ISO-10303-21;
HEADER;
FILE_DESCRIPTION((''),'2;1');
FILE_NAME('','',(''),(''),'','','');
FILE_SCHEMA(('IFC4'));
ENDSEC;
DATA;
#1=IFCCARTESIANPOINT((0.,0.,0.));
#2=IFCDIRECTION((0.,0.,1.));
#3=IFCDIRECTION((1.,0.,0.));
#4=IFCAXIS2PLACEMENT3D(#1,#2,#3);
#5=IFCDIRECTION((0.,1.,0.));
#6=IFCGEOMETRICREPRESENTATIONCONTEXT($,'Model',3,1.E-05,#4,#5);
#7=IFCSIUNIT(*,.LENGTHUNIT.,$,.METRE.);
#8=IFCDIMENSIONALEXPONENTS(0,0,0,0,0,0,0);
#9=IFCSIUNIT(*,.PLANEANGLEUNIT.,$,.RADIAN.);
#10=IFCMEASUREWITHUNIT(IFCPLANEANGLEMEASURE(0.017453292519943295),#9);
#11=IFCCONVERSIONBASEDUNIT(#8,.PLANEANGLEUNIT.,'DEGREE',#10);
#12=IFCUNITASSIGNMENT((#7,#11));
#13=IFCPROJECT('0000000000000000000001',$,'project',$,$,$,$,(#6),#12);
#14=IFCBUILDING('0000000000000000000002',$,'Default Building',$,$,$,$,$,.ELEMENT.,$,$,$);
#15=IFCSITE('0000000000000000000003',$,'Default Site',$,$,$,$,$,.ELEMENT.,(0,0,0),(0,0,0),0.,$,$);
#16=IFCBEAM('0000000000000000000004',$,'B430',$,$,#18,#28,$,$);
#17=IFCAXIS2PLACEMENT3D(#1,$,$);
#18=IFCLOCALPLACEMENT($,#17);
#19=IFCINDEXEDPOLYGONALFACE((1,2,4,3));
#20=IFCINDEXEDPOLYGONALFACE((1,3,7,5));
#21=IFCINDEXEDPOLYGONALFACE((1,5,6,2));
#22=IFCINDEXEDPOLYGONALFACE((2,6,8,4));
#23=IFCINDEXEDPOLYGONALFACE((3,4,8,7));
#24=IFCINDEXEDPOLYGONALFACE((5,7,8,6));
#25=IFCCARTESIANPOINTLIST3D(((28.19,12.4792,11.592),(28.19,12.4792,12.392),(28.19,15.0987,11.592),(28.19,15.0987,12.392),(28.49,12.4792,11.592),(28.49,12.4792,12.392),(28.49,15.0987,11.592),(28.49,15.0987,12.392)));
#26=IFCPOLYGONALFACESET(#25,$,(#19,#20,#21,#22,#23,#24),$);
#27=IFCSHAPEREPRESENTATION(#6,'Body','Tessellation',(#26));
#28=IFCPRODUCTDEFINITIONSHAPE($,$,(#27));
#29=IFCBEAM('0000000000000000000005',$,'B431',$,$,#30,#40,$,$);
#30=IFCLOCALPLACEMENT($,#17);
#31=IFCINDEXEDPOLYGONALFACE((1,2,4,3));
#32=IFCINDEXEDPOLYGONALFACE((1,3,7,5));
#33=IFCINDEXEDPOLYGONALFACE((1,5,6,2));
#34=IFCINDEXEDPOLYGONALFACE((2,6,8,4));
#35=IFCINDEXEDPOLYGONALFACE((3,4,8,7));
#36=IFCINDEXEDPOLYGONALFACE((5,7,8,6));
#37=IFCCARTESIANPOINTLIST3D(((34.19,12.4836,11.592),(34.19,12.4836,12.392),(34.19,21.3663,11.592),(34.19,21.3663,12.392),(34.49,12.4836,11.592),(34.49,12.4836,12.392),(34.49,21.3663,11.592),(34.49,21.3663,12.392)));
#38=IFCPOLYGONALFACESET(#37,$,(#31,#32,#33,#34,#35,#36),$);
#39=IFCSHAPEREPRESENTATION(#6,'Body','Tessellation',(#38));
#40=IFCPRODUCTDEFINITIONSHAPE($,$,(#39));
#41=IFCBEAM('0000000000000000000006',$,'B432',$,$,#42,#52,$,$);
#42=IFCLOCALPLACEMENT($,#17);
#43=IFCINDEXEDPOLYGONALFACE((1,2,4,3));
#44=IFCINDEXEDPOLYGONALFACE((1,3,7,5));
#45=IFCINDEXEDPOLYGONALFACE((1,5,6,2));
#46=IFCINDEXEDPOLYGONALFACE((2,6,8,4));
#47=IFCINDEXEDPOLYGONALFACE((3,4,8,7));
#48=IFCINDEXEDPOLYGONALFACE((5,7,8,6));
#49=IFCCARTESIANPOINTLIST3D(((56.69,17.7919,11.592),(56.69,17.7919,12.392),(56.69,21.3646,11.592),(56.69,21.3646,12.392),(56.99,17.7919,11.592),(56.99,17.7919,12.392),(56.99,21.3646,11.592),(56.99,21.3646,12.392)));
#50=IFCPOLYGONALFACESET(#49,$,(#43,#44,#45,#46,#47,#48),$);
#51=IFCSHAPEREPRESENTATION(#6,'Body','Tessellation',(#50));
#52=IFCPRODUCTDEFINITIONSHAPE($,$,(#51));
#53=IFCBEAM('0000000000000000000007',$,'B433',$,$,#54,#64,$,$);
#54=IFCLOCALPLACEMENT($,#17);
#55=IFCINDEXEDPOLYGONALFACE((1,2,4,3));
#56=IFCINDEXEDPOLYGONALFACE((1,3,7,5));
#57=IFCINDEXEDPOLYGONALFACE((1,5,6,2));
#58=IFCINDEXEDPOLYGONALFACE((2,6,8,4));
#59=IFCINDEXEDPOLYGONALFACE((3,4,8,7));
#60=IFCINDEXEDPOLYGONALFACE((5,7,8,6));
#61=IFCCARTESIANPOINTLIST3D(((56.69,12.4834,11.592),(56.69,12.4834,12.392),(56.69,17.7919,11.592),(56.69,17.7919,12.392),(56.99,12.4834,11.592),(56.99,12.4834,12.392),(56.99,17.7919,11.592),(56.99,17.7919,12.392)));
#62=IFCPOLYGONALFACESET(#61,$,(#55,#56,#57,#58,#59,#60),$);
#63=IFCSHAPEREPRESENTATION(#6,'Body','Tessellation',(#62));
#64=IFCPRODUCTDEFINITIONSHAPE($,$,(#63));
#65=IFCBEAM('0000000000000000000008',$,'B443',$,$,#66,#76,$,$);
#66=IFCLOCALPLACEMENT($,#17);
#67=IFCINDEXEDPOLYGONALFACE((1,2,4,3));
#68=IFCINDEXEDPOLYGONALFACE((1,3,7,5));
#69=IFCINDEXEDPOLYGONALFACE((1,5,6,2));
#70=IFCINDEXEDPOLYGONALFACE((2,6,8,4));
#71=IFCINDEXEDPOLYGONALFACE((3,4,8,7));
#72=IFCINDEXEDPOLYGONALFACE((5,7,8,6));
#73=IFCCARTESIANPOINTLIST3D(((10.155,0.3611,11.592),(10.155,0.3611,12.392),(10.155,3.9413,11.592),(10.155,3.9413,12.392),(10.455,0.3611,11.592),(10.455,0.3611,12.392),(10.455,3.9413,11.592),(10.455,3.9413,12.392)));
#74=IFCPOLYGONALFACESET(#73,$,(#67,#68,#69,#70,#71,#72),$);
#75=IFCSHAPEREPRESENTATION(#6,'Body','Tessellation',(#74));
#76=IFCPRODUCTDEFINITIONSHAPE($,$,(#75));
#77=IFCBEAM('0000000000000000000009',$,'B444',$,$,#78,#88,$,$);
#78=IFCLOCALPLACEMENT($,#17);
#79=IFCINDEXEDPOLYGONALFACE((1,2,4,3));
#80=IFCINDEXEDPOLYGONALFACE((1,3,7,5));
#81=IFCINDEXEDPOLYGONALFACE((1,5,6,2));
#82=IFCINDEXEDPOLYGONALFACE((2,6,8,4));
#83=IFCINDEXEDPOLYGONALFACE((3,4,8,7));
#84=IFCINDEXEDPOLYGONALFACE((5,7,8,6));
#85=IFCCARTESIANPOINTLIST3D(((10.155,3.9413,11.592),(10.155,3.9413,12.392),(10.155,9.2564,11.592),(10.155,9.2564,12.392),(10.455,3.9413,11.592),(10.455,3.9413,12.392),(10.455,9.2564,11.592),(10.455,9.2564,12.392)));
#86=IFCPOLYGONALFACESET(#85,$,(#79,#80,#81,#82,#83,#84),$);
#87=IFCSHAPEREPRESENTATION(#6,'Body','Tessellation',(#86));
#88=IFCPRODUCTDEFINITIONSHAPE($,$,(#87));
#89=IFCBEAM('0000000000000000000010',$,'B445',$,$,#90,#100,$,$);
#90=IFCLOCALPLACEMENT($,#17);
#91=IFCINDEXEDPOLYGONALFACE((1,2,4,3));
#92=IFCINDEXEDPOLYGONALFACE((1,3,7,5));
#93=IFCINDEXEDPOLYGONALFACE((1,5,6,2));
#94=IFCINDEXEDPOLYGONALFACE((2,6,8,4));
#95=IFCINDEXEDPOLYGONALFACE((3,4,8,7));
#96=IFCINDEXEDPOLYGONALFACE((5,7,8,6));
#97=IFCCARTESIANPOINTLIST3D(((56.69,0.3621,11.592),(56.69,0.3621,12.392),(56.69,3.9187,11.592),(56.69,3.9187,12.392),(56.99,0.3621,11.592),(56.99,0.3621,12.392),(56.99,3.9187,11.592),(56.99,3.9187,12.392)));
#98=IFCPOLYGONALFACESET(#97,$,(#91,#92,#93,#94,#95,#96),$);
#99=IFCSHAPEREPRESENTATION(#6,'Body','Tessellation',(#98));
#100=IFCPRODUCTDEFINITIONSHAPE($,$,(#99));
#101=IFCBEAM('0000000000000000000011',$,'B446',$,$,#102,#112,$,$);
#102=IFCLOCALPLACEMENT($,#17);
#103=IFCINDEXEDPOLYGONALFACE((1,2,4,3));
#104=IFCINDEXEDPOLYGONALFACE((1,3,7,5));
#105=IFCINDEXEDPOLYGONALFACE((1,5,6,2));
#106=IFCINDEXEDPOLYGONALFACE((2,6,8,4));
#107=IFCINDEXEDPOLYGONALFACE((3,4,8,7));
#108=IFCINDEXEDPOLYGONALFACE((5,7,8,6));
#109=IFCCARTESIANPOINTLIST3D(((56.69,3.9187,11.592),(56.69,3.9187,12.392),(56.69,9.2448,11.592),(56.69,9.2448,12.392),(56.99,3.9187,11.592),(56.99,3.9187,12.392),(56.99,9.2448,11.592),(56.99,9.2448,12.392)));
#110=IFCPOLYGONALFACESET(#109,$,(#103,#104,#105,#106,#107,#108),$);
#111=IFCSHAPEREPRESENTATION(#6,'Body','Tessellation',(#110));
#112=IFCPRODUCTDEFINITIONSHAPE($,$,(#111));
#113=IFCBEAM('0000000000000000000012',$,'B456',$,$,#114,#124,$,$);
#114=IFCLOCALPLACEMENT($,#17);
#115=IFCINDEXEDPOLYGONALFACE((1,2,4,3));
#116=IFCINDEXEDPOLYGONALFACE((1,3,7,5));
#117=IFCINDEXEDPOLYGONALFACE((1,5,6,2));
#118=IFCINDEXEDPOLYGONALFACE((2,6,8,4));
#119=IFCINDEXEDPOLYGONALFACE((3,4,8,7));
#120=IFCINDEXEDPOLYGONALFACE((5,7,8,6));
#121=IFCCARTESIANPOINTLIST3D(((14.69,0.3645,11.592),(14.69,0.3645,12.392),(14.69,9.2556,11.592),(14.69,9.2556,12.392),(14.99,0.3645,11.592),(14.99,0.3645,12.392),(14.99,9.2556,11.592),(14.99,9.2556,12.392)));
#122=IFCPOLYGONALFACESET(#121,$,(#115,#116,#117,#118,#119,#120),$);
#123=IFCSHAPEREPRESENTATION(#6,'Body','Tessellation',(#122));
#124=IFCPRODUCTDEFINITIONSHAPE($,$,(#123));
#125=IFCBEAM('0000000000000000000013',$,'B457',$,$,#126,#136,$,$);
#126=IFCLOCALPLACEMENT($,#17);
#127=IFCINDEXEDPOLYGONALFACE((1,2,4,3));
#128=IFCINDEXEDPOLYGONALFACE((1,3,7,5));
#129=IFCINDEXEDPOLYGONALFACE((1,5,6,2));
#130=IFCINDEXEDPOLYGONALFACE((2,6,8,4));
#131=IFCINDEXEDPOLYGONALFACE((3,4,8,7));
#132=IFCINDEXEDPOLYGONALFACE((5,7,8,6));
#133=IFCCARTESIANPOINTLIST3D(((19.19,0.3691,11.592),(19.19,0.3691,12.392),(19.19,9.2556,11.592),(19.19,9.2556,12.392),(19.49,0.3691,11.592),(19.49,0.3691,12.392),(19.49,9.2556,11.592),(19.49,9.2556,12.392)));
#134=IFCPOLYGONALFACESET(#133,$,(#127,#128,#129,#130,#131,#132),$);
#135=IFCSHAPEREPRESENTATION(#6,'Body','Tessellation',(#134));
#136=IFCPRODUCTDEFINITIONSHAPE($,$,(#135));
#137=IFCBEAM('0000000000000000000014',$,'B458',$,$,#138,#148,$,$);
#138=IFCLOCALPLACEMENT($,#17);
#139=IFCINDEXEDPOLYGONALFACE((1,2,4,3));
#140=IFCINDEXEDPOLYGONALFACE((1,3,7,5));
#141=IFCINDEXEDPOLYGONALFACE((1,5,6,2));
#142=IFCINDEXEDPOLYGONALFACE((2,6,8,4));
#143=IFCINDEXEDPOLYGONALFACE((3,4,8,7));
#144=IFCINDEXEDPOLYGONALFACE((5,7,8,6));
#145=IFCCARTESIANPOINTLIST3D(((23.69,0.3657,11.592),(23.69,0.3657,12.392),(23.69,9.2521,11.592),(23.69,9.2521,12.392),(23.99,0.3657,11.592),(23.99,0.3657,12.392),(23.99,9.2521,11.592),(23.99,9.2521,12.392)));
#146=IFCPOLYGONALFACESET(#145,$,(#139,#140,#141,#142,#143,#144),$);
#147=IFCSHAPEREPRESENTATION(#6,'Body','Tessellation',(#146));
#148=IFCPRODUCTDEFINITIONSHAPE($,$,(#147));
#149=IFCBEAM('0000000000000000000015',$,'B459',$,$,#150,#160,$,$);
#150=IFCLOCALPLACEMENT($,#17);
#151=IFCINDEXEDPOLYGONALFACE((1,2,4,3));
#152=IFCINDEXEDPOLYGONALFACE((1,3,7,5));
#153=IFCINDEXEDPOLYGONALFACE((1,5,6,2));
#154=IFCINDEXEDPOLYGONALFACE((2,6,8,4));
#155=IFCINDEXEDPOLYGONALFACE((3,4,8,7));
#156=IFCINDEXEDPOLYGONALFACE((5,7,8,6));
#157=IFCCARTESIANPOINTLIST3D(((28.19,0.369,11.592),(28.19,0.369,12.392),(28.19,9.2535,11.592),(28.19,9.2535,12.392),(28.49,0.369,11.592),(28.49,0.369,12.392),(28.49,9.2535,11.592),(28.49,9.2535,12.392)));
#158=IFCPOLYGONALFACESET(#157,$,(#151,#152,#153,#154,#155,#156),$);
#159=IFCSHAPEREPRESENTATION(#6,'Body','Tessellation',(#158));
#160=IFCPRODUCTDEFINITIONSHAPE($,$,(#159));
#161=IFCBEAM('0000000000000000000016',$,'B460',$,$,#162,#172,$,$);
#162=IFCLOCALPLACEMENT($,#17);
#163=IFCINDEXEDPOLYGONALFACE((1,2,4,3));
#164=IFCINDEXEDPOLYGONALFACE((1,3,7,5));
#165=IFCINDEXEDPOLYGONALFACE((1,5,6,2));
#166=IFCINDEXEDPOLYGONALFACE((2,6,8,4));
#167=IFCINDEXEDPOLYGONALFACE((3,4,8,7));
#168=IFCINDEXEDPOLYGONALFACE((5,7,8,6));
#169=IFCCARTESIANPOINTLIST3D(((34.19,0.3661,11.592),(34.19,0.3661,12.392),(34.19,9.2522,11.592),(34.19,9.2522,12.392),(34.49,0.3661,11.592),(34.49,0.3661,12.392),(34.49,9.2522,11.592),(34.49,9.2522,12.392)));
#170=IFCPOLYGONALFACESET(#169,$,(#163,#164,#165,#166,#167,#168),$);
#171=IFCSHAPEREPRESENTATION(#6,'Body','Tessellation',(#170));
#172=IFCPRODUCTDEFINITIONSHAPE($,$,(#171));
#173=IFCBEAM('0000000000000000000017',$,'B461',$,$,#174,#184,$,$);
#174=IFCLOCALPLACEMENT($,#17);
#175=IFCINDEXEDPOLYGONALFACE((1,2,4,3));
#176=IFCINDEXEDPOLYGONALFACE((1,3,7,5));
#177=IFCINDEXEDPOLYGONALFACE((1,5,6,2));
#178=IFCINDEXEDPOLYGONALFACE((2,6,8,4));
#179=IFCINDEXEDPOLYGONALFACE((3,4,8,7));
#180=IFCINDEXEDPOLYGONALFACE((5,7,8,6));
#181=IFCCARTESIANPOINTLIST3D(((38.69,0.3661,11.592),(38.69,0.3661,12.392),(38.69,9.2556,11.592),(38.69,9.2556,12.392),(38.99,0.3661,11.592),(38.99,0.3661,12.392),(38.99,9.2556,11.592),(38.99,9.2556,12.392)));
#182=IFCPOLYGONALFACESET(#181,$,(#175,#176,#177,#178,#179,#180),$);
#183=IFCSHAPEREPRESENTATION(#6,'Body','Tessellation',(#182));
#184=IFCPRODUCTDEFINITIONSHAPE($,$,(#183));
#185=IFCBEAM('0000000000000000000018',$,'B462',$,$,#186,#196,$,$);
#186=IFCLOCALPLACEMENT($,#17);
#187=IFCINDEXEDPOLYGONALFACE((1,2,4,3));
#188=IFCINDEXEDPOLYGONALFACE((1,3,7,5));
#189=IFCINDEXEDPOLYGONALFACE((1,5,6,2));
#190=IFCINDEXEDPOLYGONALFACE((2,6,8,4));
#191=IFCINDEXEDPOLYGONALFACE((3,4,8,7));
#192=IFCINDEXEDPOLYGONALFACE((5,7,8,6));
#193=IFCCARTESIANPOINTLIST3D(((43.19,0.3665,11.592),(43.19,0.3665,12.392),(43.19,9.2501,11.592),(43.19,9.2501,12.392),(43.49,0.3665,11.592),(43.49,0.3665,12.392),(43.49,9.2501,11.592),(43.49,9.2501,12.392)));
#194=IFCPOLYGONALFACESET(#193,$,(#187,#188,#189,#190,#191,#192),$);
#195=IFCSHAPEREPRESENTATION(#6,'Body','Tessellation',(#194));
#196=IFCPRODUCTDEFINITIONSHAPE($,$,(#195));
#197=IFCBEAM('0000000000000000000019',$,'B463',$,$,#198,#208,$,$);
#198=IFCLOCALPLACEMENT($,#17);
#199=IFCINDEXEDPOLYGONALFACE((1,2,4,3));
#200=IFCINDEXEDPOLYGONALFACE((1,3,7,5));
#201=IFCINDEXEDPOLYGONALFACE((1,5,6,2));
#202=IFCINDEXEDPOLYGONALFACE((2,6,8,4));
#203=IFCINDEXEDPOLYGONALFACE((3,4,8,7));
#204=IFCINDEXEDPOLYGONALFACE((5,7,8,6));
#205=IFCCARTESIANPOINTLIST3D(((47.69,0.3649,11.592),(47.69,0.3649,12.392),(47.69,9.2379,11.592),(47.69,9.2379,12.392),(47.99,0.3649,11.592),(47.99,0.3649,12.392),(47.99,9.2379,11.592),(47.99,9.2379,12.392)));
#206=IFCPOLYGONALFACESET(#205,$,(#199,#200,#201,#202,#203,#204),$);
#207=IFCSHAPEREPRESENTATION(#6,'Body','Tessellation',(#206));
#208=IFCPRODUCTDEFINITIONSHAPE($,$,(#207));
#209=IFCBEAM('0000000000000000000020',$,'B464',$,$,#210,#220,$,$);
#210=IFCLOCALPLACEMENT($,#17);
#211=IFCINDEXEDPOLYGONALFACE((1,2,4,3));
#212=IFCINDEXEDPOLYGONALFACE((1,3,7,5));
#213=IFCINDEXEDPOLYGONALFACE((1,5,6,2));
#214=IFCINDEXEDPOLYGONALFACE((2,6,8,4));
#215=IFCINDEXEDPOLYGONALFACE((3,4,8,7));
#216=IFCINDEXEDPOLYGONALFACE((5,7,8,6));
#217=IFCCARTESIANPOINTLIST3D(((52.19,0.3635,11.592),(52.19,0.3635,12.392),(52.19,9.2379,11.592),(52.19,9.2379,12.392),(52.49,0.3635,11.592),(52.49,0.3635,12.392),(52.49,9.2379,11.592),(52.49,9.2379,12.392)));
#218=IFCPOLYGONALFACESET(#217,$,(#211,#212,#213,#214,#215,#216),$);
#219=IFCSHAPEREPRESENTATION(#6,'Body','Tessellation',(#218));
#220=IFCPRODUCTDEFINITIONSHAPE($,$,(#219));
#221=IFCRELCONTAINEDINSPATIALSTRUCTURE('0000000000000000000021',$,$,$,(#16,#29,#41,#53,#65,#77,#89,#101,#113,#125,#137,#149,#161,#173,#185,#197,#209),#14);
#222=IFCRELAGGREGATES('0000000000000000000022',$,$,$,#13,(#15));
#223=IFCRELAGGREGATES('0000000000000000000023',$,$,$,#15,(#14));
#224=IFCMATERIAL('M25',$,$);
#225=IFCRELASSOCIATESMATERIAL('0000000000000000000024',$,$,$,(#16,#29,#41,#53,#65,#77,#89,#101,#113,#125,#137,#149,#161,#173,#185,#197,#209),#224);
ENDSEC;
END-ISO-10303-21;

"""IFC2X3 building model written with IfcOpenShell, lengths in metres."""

from ifc_helpers import new_model, entity, si_unit, converted_unit, direction, frame, frame_2d, origin_with_axes, place, context, project, spatial, rectangle, extrude, material, element, save


model = new_model("IFC2X3")

# Units and contexts
model_context = context("Model", 3, precision=1e-05, world=origin_with_axes(), true_north=direction((0.0, 1.0, 0.0)))
ifc_project = project(units=[si_unit("LENGTHUNIT", "METRE"), converted_unit("PLANEANGLEUNIT", "DEGREE", entity("IfcPlaneAngleMeasure", 0.017453292519943295), si_unit("PLANEANGLEUNIT", "RADIAN"), dimensions=[0, 0, 0, 0, 0, 0, 0])], contexts=[model_context])

# Site, building
site = spatial("IfcSite", under=ifc_project, Name="Default Site", CompositionType="ELEMENT", RefLatitude=(0, 0, 0), RefLongitude=(0, 0, 0), RefElevation=0.0)
building = spatial("IfcBuilding", under=site, Name="Default Building", CompositionType="ELEMENT")

# Beams
ifc_material = material(Name="M25")
placement = place(None, origin_with_axes())
element("IfcBeam", 1, at=placement, inside=building, material=ifc_material, Name="B430", context=model_context, shape_type="SweptSolid", body=[
    extrude(rectangle(XDim=0.3, YDim=0.8, at=frame_2d((0.0, 0.0), x_axis=(0.0, 1.0, 0.0))), frame((28.34, 15.0987, 11.992), z_axis=(0.0, -1.0, 0.0), x_axis=(0.0, 0.0, -1.0)), (0.0, 0.0, 1.0), 2.6195),
])
element("IfcBeam", 2, at=placement, inside=building, material=ifc_material, Name="B431", context=model_context, shape_type="SweptSolid", body=[
    extrude(rectangle(XDim=0.3, YDim=0.8, at=frame_2d((0.0, 0.0), x_axis=(0.0, 1.0, 0.0))), frame((34.34, 12.4836, 11.992), z_axis=(0.0, 1.0, 0.0), x_axis=(0.0, 0.0, -1.0)), (0.0, 0.0, 1.0), 8.8827),
])
element("IfcBeam", 3, at=placement, inside=building, material=ifc_material, Name="B432", context=model_context, shape_type="SweptSolid", body=[
    extrude(rectangle(XDim=0.3, YDim=0.8, at=frame_2d((0.0, 0.0), x_axis=(0.0, 1.0, 0.0))), frame((56.84, 17.7919, 11.992), z_axis=(0.0, 1.0, 0.0), x_axis=(0.0, 0.0, -1.0)), (0.0, 0.0, 1.0), 3.5727),
])
element("IfcBeam", 4, at=placement, inside=building, material=ifc_material, Name="B433", context=model_context, shape_type="SweptSolid", body=[
    extrude(rectangle(XDim=0.3, YDim=0.8, at=frame_2d((0.0, 0.0), x_axis=(0.0, 1.0, 0.0))), frame((56.84, 12.4834, 11.992), z_axis=(0.0, 1.0, 0.0), x_axis=(0.0, 0.0, -1.0)), (0.0, 0.0, 1.0), 5.3085),
])
element("IfcBeam", 5, at=placement, inside=building, material=ifc_material, Name="B443", context=model_context, shape_type="SweptSolid", body=[
    extrude(rectangle(XDim=0.3, YDim=0.8, at=frame_2d((0.0, 0.0), x_axis=(0.0, 1.0, 0.0))), frame((10.305, 3.9413, 11.992), z_axis=(0.0, -1.0, 0.0), x_axis=(0.0, 0.0, -1.0)), (0.0, 0.0, 1.0), 3.5802),
])
element("IfcBeam", 6, at=placement, inside=building, material=ifc_material, Name="B444", context=model_context, shape_type="SweptSolid", body=[
    extrude(rectangle(XDim=0.3, YDim=0.8, at=frame_2d((0.0, 0.0), x_axis=(0.0, 1.0, 0.0))), frame((10.305, 3.9413, 11.992), z_axis=(0.0, 1.0, 0.0), x_axis=(0.0, 0.0, -1.0)), (0.0, 0.0, 1.0), 5.3151),
])
element("IfcBeam", 7, at=placement, inside=building, material=ifc_material, Name="B445", context=model_context, shape_type="SweptSolid", body=[
    extrude(rectangle(XDim=0.3, YDim=0.8, at=frame_2d((0.0, 0.0), x_axis=(0.0, 1.0, 0.0))), frame((56.84, 0.3621, 11.992), z_axis=(0.0, 1.0, 0.0), x_axis=(0.0, 0.0, -1.0)), (0.0, 0.0, 1.0), 3.5566),
])
element("IfcBeam", 8, at=placement, inside=building, material=ifc_material, Name="B446", context=model_context, shape_type="SweptSolid", body=[
    extrude(rectangle(XDim=0.3, YDim=0.8, at=frame_2d((0.0, 0.0), x_axis=(0.0, 1.0, 0.0))), frame((56.84, 3.9187, 11.992), z_axis=(0.0, 1.0, 0.0), x_axis=(0.0, 0.0, -1.0)), (0.0, 0.0, 1.0), 5.3261),
])
element("IfcBeam", 9, at=placement, inside=building, material=ifc_material, Name="B456", context=model_context, shape_type="SweptSolid", body=[
    extrude(rectangle(XDim=0.3, YDim=0.8, at=frame_2d((0.0, 0.0), x_axis=(0.0, 1.0, 0.0))), frame((14.84, 0.3645, 11.992), z_axis=(0.0, 1.0, 0.0), x_axis=(0.0, 0.0, -1.0)), (0.0, 0.0, 1.0), 8.891),
])
element("IfcBeam", 10, at=placement, inside=building, material=ifc_material, Name="B457", context=model_context, shape_type="SweptSolid", body=[
    extrude(rectangle(XDim=0.3, YDim=0.8, at=frame_2d((0.0, 0.0), x_axis=(0.0, 1.0, 0.0))), frame((19.34, 0.3691, 11.992), z_axis=(0.0, 1.0, 0.0), x_axis=(0.0, 0.0, -1.0)), (0.0, 0.0, 1.0), 8.8865),
])
element("IfcBeam", 11, at=placement, inside=building, material=ifc_material, Name="B458", context=model_context, shape_type="SweptSolid", body=[
    extrude(rectangle(XDim=0.3, YDim=0.8, at=frame_2d((0.0, 0.0), x_axis=(0.0, 1.0, 0.0))), frame((23.84, 0.3657, 11.992), z_axis=(0.0, 1.0, 0.0), x_axis=(0.0, 0.0, -1.0)), (0.0, 0.0, 1.0), 8.8864),
])
element("IfcBeam", 12, at=placement, inside=building, material=ifc_material, Name="B459", context=model_context, shape_type="SweptSolid", body=[
    extrude(rectangle(XDim=0.3, YDim=0.8, at=frame_2d((0.0, 0.0), x_axis=(0.0, 1.0, 0.0))), frame((28.34, 0.369, 11.992), z_axis=(0.0, 1.0, 0.0), x_axis=(0.0, 0.0, -1.0)), (0.0, 0.0, 1.0), 8.8845),
])
element("IfcBeam", 13, at=placement, inside=building, material=ifc_material, Name="B460", context=model_context, shape_type="SweptSolid", body=[
    extrude(rectangle(XDim=0.3, YDim=0.8, at=frame_2d((0.0, 0.0), x_axis=(0.0, 1.0, 0.0))), frame((34.34, 0.3661, 11.992), z_axis=(0.0, 1.0, 0.0), x_axis=(0.0, 0.0, -1.0)), (0.0, 0.0, 1.0), 8.8861),
])
element("IfcBeam", 14, at=placement, inside=building, material=ifc_material, Name="B461", context=model_context, shape_type="SweptSolid", body=[
    extrude(rectangle(XDim=0.3, YDim=0.8, at=frame_2d((0.0, 0.0), x_axis=(0.0, 1.0, 0.0))), frame((38.84, 0.3661, 11.992), z_axis=(0.0, 1.0, 0.0), x_axis=(0.0, 0.0, -1.0)), (0.0, 0.0, 1.0), 8.8895),
])
element("IfcBeam", 15, at=placement, inside=building, material=ifc_material, Name="B462", context=model_context, shape_type="SweptSolid", body=[
    extrude(rectangle(XDim=0.3, YDim=0.8, at=frame_2d((0.0, 0.0), x_axis=(0.0, 1.0, 0.0))), frame((43.34, 0.3665, 11.992), z_axis=(0.0, 1.0, 0.0), x_axis=(0.0, 0.0, -1.0)), (0.0, 0.0, 1.0), 8.8836),
])
element("IfcBeam", 16, at=placement, inside=building, material=ifc_material, Name="B463", context=model_context, shape_type="SweptSolid", body=[
    extrude(rectangle(XDim=0.3, YDim=0.8, at=frame_2d((0.0, 0.0), x_axis=(0.0, 1.0, 0.0))), frame((47.84, 0.3649, 11.992), z_axis=(0.0, 1.0, 0.0), x_axis=(0.0, 0.0, -1.0)), (0.0, 0.0, 1.0), 8.873),
])
element("IfcBeam", 17, at=placement, inside=building, material=ifc_material, Name="B464", context=model_context, shape_type="SweptSolid", body=[
    extrude(rectangle(XDim=0.3, YDim=0.8, at=frame_2d((0.0, 0.0), x_axis=(0.0, 1.0, 0.0))), frame((52.34, 0.3635, 11.992), z_axis=(0.0, 1.0, 0.0), x_axis=(0.0, 0.0, -1.0)), (0.0, 0.0, 1.0), 8.8744),
])

save(model, "model.ifc")
